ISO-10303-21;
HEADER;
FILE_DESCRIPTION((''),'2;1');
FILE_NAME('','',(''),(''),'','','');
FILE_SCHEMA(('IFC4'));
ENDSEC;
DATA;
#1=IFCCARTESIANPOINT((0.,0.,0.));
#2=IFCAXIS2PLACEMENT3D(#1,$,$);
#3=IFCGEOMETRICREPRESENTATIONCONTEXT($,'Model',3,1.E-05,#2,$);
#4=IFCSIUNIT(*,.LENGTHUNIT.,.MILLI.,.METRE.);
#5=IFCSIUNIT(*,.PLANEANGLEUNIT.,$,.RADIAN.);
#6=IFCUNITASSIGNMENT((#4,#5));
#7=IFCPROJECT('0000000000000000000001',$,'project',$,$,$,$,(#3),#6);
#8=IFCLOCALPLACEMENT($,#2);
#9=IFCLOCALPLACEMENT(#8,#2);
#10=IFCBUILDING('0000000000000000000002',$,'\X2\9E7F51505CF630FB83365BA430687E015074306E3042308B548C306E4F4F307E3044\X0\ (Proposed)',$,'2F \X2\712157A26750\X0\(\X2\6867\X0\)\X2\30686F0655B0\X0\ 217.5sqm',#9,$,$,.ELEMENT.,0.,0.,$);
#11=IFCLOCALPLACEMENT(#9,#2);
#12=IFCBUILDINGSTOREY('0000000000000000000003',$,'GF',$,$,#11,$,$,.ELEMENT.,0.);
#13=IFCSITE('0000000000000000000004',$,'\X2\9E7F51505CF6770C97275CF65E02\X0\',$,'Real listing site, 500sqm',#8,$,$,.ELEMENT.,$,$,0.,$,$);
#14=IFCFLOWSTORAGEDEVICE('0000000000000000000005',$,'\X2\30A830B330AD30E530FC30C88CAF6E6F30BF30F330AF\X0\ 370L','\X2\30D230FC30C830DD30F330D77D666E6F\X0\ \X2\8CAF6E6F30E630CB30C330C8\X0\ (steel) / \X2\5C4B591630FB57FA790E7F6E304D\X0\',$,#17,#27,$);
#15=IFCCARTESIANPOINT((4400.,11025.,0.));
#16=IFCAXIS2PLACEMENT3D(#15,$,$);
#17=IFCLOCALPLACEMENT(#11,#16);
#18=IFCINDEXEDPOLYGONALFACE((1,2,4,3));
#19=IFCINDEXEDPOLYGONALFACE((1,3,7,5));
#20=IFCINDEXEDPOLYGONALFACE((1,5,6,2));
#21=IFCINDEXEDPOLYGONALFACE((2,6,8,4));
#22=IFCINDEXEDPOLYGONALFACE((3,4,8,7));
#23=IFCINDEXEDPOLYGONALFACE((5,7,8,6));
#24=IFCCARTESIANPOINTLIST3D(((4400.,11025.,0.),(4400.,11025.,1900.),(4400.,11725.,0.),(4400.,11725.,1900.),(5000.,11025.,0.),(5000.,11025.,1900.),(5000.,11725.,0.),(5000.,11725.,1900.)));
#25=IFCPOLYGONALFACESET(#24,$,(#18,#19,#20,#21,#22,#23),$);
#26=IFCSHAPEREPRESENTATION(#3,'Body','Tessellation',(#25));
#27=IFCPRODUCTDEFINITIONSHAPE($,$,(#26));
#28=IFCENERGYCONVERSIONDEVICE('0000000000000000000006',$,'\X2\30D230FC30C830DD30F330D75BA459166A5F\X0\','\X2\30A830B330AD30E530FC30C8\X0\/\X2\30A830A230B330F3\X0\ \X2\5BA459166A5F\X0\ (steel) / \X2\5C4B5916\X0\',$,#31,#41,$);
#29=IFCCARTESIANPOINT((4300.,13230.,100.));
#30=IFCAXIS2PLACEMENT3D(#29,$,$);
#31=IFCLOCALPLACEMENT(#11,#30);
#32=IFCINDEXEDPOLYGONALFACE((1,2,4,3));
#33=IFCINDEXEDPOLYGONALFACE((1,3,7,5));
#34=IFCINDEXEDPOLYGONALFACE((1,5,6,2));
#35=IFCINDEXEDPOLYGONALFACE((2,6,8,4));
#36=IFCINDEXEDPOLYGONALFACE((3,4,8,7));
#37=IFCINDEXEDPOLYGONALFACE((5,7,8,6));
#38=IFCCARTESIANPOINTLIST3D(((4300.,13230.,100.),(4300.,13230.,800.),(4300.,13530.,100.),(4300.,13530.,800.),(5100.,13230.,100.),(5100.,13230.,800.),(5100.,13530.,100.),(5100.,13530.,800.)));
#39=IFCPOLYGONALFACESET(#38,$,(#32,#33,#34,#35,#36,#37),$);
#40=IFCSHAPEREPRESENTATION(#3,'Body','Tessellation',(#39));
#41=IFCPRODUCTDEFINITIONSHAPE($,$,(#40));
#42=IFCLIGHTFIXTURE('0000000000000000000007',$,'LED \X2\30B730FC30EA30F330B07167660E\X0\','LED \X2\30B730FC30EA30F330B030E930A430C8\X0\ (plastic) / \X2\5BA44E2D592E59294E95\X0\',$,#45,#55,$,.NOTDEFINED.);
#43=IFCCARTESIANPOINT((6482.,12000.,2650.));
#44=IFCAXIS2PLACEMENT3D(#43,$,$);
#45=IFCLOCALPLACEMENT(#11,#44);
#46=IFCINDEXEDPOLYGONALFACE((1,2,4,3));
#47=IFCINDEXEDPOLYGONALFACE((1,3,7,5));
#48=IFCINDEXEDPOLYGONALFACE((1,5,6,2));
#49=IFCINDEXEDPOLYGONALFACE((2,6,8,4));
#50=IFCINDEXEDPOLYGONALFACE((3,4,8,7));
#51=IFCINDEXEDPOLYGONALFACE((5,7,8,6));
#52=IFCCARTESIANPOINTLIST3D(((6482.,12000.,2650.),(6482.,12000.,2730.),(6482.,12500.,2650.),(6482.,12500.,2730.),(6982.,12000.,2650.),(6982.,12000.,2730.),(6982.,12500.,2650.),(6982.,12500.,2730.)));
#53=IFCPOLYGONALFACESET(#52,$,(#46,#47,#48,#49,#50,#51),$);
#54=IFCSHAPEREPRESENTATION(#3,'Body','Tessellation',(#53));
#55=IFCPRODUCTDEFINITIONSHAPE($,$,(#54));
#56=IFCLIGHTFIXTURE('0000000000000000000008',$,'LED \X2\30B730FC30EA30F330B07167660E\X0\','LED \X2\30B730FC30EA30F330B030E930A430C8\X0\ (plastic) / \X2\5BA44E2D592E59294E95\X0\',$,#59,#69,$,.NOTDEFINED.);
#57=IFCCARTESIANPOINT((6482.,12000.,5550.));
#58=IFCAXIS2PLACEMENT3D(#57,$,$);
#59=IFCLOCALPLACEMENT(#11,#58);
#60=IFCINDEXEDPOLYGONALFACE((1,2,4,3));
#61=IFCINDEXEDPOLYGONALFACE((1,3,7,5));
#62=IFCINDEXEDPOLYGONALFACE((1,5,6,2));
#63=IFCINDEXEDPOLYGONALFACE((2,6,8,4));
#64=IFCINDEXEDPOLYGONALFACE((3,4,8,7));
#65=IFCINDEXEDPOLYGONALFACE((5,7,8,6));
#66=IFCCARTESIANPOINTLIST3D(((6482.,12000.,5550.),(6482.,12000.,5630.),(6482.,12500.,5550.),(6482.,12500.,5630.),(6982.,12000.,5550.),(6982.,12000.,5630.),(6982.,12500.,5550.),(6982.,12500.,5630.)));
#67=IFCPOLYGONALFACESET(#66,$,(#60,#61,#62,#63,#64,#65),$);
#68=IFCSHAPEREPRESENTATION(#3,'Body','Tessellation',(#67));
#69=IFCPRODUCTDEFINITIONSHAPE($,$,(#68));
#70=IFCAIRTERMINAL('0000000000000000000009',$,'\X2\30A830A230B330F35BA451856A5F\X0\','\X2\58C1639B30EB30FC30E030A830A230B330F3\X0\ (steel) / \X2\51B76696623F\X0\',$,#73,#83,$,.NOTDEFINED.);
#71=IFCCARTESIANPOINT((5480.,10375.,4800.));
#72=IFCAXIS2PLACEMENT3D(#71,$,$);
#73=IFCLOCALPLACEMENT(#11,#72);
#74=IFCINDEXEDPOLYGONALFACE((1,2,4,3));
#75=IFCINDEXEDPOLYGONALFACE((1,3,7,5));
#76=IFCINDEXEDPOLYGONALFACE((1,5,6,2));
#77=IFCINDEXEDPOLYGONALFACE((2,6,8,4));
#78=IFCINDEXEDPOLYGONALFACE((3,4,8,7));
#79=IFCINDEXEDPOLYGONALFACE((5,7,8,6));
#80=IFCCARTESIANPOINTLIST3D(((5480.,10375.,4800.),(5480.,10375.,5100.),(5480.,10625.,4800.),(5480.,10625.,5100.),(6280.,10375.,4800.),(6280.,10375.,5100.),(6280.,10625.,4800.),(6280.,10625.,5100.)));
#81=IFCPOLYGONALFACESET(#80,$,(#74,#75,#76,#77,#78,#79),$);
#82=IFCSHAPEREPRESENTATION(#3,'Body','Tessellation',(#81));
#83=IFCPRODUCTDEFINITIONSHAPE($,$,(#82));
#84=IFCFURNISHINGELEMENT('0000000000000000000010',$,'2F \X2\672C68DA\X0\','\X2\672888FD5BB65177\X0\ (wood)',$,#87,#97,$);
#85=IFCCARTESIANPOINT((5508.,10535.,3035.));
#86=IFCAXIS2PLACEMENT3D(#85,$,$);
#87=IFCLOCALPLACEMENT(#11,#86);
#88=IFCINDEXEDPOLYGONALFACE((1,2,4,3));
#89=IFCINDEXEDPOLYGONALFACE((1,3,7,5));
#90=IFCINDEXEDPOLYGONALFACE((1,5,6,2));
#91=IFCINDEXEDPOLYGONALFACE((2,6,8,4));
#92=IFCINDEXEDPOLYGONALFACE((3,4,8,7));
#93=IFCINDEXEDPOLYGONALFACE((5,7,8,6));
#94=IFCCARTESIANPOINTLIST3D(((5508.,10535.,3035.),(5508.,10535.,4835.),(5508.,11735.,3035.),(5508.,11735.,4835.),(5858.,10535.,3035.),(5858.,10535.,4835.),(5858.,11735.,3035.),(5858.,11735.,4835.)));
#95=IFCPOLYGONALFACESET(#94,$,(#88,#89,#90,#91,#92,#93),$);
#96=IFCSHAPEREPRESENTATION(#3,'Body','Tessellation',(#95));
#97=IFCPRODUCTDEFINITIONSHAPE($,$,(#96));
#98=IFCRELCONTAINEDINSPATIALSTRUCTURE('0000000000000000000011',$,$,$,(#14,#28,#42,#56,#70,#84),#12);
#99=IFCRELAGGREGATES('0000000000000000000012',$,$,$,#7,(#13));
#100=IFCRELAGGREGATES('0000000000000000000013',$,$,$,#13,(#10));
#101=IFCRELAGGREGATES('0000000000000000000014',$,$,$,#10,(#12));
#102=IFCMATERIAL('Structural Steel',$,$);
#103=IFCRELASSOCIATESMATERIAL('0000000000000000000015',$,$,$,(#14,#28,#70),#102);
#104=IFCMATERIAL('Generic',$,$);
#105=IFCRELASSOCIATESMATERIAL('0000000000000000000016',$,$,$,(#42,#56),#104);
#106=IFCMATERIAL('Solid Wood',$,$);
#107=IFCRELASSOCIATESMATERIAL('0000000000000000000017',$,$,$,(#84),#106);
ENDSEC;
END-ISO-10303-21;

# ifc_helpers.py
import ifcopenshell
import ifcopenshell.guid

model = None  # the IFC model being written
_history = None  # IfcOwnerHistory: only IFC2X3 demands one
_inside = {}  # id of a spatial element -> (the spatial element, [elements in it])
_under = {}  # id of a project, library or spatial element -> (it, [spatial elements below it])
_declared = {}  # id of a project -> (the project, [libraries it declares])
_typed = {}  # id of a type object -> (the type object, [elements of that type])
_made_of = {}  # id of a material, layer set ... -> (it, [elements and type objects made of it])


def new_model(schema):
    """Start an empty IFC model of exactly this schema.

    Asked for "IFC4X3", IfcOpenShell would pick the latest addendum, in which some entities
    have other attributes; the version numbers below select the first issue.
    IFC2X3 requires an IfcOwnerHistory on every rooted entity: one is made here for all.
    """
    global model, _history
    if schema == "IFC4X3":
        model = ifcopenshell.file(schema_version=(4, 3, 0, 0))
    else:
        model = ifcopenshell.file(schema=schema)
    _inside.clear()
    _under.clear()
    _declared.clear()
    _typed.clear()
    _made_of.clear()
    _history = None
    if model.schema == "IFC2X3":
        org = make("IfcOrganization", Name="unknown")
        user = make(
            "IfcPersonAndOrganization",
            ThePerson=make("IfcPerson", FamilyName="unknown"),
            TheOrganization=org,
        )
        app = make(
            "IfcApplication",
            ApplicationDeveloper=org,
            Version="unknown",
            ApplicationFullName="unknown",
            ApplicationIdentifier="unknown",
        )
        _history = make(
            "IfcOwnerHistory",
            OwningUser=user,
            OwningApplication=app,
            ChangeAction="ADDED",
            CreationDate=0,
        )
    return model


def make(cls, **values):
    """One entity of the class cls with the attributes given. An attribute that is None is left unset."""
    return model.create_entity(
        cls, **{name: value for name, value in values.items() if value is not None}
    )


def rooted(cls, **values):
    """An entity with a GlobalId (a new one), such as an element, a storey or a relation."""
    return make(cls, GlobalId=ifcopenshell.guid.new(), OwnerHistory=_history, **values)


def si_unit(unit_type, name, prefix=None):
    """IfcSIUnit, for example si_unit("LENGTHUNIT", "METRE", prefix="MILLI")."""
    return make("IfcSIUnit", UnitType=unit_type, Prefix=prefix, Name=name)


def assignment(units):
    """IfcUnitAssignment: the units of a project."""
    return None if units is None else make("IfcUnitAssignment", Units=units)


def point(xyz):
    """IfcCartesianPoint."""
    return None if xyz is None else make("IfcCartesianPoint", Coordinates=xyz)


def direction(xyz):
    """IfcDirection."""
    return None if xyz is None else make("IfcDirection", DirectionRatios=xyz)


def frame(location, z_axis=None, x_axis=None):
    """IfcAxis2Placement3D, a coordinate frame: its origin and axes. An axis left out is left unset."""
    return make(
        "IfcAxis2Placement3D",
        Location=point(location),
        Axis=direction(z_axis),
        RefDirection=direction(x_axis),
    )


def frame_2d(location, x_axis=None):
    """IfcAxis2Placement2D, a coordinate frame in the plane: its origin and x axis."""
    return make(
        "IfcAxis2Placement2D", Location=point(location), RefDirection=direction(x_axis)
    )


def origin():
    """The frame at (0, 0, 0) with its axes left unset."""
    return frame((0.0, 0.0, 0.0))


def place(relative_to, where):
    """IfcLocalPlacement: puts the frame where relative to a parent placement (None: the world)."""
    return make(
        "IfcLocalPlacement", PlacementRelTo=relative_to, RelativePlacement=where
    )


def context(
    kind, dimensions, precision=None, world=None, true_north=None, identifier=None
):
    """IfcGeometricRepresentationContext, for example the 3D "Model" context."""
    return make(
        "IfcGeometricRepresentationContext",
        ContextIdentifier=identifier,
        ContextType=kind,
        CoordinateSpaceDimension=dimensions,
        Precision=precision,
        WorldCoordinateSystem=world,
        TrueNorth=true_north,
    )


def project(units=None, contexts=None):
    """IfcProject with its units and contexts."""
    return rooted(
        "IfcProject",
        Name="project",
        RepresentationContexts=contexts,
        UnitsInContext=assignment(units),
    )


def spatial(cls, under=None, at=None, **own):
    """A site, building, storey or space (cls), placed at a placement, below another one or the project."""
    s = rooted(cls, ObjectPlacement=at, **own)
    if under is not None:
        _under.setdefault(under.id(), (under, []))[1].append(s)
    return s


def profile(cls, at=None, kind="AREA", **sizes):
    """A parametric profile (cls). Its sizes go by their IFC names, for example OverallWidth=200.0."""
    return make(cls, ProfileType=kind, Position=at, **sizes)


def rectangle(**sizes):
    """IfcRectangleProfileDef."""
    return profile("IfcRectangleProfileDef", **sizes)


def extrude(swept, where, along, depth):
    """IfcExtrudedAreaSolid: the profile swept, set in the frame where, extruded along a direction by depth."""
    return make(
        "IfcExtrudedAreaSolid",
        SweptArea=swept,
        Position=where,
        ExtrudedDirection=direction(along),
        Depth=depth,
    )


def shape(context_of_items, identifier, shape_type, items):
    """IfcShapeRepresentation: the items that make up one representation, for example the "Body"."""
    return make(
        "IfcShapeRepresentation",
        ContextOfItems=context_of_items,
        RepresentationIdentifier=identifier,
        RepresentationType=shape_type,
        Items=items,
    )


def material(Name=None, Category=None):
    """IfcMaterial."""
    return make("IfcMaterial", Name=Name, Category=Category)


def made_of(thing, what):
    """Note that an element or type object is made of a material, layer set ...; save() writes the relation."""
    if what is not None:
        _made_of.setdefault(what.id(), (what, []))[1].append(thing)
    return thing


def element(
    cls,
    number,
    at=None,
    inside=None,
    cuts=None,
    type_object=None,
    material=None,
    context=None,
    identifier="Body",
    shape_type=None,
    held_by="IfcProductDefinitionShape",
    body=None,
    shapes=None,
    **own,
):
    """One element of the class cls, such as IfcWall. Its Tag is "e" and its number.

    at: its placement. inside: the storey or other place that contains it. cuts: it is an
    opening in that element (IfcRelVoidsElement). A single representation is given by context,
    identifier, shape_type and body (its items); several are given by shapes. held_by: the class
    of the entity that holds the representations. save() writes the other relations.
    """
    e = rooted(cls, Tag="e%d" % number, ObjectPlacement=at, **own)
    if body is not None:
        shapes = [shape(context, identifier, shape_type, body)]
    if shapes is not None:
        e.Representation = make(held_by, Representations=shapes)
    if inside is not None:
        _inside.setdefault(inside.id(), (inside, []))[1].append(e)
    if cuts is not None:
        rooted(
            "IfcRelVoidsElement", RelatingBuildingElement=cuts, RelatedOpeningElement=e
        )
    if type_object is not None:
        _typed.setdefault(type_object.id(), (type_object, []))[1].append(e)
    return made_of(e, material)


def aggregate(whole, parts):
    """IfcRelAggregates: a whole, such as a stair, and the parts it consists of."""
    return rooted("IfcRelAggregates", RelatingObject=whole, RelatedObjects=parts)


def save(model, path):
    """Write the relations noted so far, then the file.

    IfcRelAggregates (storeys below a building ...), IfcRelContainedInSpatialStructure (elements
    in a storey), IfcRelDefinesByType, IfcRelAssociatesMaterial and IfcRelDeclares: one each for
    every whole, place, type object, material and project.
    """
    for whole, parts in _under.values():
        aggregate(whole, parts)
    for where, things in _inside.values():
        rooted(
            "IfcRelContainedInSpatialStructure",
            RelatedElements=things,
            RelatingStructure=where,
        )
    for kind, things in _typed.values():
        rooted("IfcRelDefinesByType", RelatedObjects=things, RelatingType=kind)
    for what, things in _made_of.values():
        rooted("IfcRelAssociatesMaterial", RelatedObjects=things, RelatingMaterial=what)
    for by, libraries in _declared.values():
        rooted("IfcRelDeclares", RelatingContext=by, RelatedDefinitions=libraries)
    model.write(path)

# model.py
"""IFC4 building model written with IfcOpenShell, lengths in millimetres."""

from ifc_helpers import new_model, si_unit, frame, frame_2d, origin, place, context, project, spatial, rectangle, extrude, material, element, save


model = new_model("IFC4")

# Units and contexts
model_context = context("Model", 3, precision=1e-05, world=origin())
ifc_project = project(units=[si_unit("LENGTHUNIT", "METRE", prefix="MILLI"), si_unit("PLANEANGLEUNIT", "RADIAN")], contexts=[model_context])

# Site, building, storey
site_placement = place(None, origin())
site = spatial("IfcSite", under=ifc_project, at=site_placement, Name="鹿児島県霧島市", ObjectType="Real listing site, 500sqm", CompositionType="ELEMENT", RefElevation=0.0)
building_placement = place(site_placement, origin())
building = spatial("IfcBuilding", under=site, at=building_placement, Name="鹿児島・茶室と縁側のある和の住まい (Proposed)", ObjectType="2F 無垢材(桧)と漆喰 217.5sqm", CompositionType="ELEMENT", ElevationOfRefHeight=0.0, ElevationOfTerrain=0.0)
storey_placement = place(building_placement, origin())
storey = spatial("IfcBuildingStorey", under=building, at=storey_placement, Name="GF", CompositionType="ELEMENT", Elevation=0.0)

# Shared definitions
ifc_material_1 = material(Name="Solid Wood")

# Shared definitions
ifc_material_2 = material(Name="Structural Steel")

# Shared definitions
ifc_material_3 = material(Name="Generic")

# Flow storage device
flow_storage_device_placement = place(storey_placement, frame((4400.0, 11025.0, 0.0)))
element("IfcFlowStorageDevice", 1, at=flow_storage_device_placement, inside=storey, material=ifc_material_2, Name="エコキュート貯湯タンク 370L", Description="ヒートポンプ給湯 貯湯ユニット (steel) / 屋外・基礎置き", context=model_context, shape_type="SweptSolid", body=[
    extrude(rectangle(XDim=600.0, YDim=700.0, at=frame_2d((300.0, 350.0))), frame((4400.0, 11025.0, 0.0)), (0.0, 0.0, 1.0), 1900.0),
])

# Energy conversion device
energy_conversion_device_placement = place(storey_placement, frame((4300.0, 13230.0, 100.0)))
element("IfcEnergyConversionDevice", 2, at=energy_conversion_device_placement, inside=storey, material=ifc_material_2, Name="ヒートポンプ室外機", Description="エコキュート/エアコン 室外機 (steel) / 屋外", context=model_context, shape_type="SweptSolid", body=[
    extrude(rectangle(XDim=800.0, YDim=300.0, at=frame_2d((400.0, 150.0))), frame((4300.0, 13230.0, 100.0)), (0.0, 0.0, 1.0), 700.0),
])

# Light fixtures
light_fixture_1_placement = place(storey_placement, frame((6482.0, 12000.0, 2650.0)))
element("IfcLightFixture", 3, at=light_fixture_1_placement, inside=storey, material=ifc_material_3, Name="LED シーリング照明", Description="LED シーリングライト (plastic) / 室中央天井", PredefinedType="NOTDEFINED", context=model_context, shape_type="SweptSolid", body=[
    extrude(rectangle(XDim=500.0, YDim=500.0, at=frame_2d((250.0, 250.0))), frame((6482.0, 12000.0, 2650.0)), (0.0, 0.0, 1.0), 80.0),
])
light_fixture_2_placement = place(storey_placement, frame((6482.0, 12000.0, 5550.0)))
element("IfcLightFixture", 4, at=light_fixture_2_placement, inside=storey, material=ifc_material_3, Name="LED シーリング照明", Description="LED シーリングライト (plastic) / 室中央天井", PredefinedType="NOTDEFINED", context=model_context, shape_type="SweptSolid", body=[
    extrude(rectangle(XDim=500.0, YDim=500.0, at=frame_2d((250.0, 250.0))), frame((6482.0, 12000.0, 5550.0)), (0.0, 0.0, 1.0), 80.0),
])

# Air terminal
air_terminal_placement = place(storey_placement, frame((5480.0, 10375.0, 4800.0)))
element("IfcAirTerminal", 5, at=air_terminal_placement, inside=storey, material=ifc_material_2, Name="エアコン室内機", Description="壁掛ルームエアコン (steel) / 冷暖房", PredefinedType="NOTDEFINED", context=model_context, shape_type="SweptSolid", body=[
    extrude(rectangle(XDim=800.0, YDim=250.0, at=frame_2d((400.0, 125.0))), frame((5480.0, 10375.0, 4800.0)), (0.0, 0.0, 1.0), 300.0),
])

# Furnishing element
furnishing_placement = place(storey_placement, frame((5508.0, 10535.0, 3035.0)))
element("IfcFurnishingElement", 6, at=furnishing_placement, inside=storey, material=ifc_material_1, Name="2F 本棚", Description="木製家具 (wood)", context=model_context, shape_type="SweptSolid", body=[
    extrude(rectangle(XDim=350.0, YDim=1200.0, at=frame_2d((175.0, 600.0))), frame((5508.0, 10535.0, 3035.0)), (0.0, 0.0, 1.0), 1800.0),
])

save(model, "model.ifc")
